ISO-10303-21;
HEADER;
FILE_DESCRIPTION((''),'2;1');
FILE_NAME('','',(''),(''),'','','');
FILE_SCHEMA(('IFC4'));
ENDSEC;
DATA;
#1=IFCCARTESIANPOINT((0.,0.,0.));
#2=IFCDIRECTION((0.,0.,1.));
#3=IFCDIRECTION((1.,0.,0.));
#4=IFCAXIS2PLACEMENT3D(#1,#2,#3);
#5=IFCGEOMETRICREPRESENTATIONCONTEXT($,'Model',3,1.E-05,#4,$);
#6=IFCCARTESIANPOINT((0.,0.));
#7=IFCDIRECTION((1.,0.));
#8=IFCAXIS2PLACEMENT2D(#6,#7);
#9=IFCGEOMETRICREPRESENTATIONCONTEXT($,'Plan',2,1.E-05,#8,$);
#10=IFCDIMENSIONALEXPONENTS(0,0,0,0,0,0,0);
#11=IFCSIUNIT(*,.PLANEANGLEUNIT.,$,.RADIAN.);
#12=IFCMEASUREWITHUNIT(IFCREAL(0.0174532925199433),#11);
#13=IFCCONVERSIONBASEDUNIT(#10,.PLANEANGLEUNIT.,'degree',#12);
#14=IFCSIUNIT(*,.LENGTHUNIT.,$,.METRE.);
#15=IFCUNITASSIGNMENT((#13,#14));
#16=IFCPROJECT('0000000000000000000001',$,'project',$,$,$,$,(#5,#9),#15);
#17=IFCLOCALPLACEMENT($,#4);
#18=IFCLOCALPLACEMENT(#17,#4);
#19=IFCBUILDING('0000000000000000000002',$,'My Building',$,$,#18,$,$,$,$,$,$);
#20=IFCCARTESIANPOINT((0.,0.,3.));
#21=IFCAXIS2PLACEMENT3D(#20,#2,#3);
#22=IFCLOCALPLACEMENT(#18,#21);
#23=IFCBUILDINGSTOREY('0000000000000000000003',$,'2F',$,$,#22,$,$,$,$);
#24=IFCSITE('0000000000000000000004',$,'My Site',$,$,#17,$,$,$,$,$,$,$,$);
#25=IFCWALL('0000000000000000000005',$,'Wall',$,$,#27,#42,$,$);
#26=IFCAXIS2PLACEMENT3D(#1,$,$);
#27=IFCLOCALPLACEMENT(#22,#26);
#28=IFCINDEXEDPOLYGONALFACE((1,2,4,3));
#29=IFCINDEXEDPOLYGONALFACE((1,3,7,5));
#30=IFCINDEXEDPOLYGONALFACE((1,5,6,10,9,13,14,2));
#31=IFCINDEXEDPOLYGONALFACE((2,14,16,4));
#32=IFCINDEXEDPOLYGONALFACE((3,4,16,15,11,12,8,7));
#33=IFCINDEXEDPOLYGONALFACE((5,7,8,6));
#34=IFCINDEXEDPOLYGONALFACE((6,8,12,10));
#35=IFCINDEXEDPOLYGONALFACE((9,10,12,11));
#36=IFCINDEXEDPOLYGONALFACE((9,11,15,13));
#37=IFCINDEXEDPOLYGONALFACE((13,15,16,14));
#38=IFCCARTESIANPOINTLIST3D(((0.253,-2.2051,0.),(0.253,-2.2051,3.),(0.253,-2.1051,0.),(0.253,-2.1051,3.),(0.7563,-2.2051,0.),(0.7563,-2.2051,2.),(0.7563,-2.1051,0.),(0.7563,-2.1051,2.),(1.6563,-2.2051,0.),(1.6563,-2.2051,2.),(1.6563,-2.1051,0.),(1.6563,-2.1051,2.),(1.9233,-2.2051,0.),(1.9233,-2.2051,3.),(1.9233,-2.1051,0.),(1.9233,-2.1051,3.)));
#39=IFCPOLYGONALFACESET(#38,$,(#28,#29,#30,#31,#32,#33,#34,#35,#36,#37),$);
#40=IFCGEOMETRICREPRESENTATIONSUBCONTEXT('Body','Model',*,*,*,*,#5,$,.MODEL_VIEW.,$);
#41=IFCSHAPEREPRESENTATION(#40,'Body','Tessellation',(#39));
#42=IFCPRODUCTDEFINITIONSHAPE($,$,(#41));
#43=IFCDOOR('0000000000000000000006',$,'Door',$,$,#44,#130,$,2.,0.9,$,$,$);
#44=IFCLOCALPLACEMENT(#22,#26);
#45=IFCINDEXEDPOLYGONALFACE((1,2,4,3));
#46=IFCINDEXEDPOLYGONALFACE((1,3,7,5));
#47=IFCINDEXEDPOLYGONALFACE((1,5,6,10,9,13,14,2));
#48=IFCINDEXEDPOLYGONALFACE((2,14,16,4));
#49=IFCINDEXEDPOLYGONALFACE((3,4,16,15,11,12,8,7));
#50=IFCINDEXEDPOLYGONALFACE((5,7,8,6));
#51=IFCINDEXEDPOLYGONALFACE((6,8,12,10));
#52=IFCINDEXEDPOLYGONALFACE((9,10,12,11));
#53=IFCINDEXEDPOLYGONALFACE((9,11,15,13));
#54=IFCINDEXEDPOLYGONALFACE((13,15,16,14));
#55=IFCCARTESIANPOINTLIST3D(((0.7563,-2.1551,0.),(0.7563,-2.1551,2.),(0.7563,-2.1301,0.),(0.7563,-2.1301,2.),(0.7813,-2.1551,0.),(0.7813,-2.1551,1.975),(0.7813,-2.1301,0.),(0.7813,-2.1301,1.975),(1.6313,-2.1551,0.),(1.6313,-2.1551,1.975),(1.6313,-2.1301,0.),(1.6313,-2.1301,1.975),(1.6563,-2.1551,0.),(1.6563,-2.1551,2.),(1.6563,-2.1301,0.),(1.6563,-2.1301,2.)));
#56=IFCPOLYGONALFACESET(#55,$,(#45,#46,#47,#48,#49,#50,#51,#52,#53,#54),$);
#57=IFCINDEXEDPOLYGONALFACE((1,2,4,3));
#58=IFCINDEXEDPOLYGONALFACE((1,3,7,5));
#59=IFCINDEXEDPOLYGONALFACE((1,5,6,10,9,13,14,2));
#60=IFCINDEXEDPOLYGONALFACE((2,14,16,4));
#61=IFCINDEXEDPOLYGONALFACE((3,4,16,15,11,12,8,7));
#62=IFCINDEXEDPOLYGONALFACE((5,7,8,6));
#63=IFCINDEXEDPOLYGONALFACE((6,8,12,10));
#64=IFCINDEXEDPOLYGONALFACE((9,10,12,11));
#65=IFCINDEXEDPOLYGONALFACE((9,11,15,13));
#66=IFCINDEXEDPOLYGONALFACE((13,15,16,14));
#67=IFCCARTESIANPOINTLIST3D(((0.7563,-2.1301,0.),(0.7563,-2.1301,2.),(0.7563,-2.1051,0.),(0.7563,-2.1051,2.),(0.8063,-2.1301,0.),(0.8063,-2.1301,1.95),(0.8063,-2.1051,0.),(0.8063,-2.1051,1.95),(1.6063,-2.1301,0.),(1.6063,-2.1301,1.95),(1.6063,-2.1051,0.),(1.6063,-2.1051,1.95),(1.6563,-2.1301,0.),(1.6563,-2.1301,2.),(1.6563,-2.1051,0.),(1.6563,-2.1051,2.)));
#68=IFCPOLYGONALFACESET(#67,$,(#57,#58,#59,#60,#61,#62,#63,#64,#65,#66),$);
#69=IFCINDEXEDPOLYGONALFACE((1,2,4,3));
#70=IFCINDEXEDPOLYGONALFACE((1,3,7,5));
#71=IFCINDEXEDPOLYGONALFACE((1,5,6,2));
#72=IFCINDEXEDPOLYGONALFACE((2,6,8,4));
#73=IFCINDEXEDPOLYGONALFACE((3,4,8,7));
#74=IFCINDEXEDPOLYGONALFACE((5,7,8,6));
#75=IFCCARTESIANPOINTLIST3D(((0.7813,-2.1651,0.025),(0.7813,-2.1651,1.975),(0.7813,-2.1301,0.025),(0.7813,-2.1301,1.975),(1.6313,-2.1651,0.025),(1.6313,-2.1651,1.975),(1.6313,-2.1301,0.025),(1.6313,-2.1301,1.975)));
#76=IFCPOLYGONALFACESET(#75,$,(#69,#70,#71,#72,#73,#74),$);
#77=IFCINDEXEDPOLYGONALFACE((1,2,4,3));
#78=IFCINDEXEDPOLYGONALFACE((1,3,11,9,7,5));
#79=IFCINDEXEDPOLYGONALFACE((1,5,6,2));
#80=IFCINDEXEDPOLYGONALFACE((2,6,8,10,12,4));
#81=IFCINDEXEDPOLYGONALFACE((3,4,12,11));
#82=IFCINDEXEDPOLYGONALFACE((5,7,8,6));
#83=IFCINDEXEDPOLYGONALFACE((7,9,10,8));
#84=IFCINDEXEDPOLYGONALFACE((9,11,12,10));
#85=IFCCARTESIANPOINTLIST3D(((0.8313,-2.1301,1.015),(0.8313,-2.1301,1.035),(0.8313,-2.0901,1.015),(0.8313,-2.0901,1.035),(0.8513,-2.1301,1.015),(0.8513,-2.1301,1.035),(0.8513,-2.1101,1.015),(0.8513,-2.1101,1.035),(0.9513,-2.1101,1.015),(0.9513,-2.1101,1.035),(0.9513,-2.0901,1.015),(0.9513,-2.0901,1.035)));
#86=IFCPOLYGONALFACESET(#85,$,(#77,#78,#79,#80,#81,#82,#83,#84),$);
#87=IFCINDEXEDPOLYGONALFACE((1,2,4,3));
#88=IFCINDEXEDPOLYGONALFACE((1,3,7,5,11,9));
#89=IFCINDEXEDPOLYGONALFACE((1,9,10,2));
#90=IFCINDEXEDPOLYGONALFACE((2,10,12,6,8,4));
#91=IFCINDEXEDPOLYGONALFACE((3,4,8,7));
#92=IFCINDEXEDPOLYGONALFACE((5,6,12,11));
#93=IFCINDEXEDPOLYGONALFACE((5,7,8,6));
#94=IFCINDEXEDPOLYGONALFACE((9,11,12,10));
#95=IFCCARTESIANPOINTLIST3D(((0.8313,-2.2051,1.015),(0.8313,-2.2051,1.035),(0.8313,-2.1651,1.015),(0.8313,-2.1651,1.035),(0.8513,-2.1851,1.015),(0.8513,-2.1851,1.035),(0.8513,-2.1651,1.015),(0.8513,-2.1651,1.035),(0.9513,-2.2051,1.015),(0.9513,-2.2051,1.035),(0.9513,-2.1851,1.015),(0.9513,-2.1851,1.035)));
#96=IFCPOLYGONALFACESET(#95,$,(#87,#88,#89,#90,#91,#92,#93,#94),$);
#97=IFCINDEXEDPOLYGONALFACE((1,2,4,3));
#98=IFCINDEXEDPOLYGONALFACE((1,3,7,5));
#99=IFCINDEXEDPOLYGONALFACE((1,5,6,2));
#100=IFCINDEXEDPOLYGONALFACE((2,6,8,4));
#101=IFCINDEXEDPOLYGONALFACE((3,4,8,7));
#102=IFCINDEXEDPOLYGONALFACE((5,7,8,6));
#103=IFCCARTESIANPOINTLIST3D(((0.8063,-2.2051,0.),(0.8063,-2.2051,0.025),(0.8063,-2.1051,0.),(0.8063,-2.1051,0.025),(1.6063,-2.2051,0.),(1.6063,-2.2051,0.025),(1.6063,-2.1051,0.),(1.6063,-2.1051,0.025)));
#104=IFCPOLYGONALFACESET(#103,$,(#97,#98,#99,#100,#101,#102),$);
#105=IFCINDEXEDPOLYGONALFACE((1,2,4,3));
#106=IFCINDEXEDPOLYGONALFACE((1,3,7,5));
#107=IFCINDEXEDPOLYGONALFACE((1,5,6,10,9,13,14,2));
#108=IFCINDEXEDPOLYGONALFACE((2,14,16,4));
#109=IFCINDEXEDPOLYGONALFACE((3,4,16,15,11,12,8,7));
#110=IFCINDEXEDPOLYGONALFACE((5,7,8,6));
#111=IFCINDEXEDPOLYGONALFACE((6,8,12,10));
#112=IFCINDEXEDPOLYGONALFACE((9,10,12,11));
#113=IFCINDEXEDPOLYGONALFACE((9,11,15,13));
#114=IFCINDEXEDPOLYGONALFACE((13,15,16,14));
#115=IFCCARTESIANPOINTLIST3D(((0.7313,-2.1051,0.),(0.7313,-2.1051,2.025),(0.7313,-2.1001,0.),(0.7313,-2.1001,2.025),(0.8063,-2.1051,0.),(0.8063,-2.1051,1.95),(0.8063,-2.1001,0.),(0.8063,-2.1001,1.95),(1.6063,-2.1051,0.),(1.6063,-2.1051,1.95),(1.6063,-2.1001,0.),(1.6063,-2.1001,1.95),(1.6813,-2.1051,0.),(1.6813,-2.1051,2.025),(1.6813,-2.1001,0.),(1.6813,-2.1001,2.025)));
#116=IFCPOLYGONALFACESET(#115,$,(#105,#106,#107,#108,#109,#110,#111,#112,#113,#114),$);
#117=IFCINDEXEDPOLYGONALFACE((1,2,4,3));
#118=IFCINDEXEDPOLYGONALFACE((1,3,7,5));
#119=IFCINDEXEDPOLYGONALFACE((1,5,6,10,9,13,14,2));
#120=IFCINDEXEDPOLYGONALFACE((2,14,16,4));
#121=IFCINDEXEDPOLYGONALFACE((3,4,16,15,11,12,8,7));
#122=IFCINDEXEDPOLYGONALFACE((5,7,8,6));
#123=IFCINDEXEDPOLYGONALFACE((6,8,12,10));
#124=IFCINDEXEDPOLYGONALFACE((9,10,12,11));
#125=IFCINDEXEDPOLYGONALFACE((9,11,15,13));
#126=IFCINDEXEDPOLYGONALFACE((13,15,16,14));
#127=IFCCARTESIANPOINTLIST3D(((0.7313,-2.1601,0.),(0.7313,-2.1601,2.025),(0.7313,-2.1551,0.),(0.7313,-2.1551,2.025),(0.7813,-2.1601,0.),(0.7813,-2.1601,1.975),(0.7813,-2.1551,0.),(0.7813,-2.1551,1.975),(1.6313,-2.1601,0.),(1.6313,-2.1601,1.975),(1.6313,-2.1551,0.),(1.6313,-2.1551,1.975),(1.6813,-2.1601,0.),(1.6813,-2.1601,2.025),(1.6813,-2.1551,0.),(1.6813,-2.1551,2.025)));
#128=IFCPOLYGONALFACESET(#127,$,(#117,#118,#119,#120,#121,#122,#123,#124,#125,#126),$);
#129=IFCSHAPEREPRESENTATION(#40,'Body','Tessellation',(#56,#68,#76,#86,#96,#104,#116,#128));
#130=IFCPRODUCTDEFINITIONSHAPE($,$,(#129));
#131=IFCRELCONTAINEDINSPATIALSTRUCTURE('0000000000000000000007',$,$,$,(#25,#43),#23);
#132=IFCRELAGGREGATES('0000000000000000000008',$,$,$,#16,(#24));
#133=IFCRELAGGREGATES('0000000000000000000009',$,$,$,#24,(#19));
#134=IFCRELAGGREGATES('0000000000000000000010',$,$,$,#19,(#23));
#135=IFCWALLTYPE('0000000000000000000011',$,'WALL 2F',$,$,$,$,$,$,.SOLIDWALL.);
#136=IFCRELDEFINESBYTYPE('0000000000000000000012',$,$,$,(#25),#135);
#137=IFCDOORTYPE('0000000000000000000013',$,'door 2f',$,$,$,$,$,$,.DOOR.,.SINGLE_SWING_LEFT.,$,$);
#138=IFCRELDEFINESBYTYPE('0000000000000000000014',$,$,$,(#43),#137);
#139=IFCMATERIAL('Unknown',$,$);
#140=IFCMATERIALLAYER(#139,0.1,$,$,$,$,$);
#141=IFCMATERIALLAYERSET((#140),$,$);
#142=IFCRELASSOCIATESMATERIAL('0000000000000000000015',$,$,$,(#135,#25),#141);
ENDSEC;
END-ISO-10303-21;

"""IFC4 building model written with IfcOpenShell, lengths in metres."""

from ifc_helpers import new_model, entity, si_unit, converted_unit, frame, origin_with_axes, origin_2d_with_axis, place, context, subcontext, project, spatial, line, indexed_curve, outline, extrude, shape, source, transform, mapped, material, layer, layer_set, layer_usage, type_object, type_shapes, element, fill, save


model = new_model("IFC4")

# Units and contexts
model_context = context("Model", 3, precision=1e-05, world=origin_with_axes())
plan_context = context("Plan", 2, precision=1e-05, world=origin_2d_with_axis())
body_context_1 = subcontext(model_context, "Body", "Model", "MODEL_VIEW")
body_context_2 = subcontext(plan_context, "Body", "Plan", "PLAN_VIEW")
ifc_project = project(units=[converted_unit("PLANEANGLEUNIT", "degree", entity("IfcReal", 0.0174532925199433), si_unit("PLANEANGLEUNIT", "RADIAN"), dimensions=[0, 0, 0, 0, 0, 0, 0]), si_unit("LENGTHUNIT", "METRE")], contexts=[model_context, plan_context])

# Site, building, storey
site_placement = place(None, origin_with_axes())
site = spatial("IfcSite", under=ifc_project, at=site_placement, Name="My Site")
building_placement = place(site_placement, origin_with_axes())
building = spatial("IfcBuilding", under=site, at=building_placement, Name="My Building")
storey_placement = place(building_placement, frame((0.0, 0.0, 3.0), z_axis=(0.0, 0.0, 1.0), x_axis=(1.0, 0.0, 0.0)))
storey = spatial("IfcBuildingStorey", under=building, at=storey_placement, Name="2F")

# Shared definitions
ifc_material = material(Name="Unknown")

# Shared definitions
ifc_layer = layer(ifc_material, 0.1)
ifc_layer_set = layer_set([ifc_layer])
wall_type = type_object("IfcWallType", Name="WALL 2F", PredefinedType="SOLIDWALL", material=ifc_layer_set)

# Wall, opening, door
ifc_layer_usage_1 = layer_usage(ifc_layer_set, "AXIS2", "POSITIVE", 0.0)
wall_1_placement = place(storey_placement, frame((1.9233, -2.1051, 0.0), z_axis=(0.0, 0.0, 1.0), x_axis=(-1.0, 0.0, 0.0)))
wall_1 = element("IfcWall", 1, at=wall_1_placement, inside=storey, type_object=wall_type, material=ifc_layer_usage_1, Name="Wall", context=body_context_1, shape_type="SweptSolid", body=[
    extrude(outline(indexed_curve([(0.0, 0.0), (0.0, 0.1), (1.6703, 0.1), (1.6703, 0.0)], segments=[line(1, 2, 3, 4, 1)])), origin_with_axes(), (0.0, 0.0, 1.0), 3.0),
])
shared_shape_1 = source(origin_with_axes(), body_context_1, "Body", "SweptSolid", [
    extrude(outline(indexed_curve([(0.0, 0.0), (0.9, 0.0), (0.9, 2.0), (0.0, 2.0)], segments=[line(1, 2, 3, 4, 1)])), frame((0.0, -0.6, 0.0), z_axis=(0.0, -1.0, 0.0), x_axis=(1.0, 0.0, 0.0)), (0.0, 0.0, -1.0), 1.2),
])
opening_1_placement = place(wall_1_placement, frame((0.2669, 0.0, 0.0), z_axis=(0.0, 0.0, 1.0), x_axis=(1.0, 0.0, 0.0)))
opening_1 = element("IfcOpeningElement", 2, at=opening_1_placement, cuts=wall_1, PredefinedType="OPENING", context=body_context_1, shape_type="MappedRepresentation", body=[
    mapped(shared_shape_1, transform((0.0, 0.0, 0.0), x_axis=(1.0, 0.0, 0.0), y_axis=(0.0, 1.0, 0.0), z_axis=(0.0, 0.0, 1.0), scale=1.0)),
])
door_type_1 = type_object("IfcDoorType", Name="door 2f", OperationType="SINGLE_SWING_LEFT", PredefinedType="DOOR")
shared_shape_2 = source(origin_with_axes(), body_context_1, "Body", "SweptSolid", [
    extrude(outline(indexed_curve([(0.0, 0.0), (0.0, 2.0), (0.9, 2.0), (0.9, 0.0), (0.875, 0.0), (0.875, 1.975), (0.025, 1.975), (0.025, 0.0)], segments=[line(1, 2, 3, 4, 5, 6, 7, 8, 1)])), frame((0.0, 0.025, 0.0), z_axis=(0.0, -1.0, 0.0), x_axis=(1.0, 0.0, 0.0)), (0.0, 0.0, -1.0), 0.025),
    extrude(outline(indexed_curve([(0.0, 0.0), (0.0, 2.0), (0.9, 2.0), (0.9, 0.0), (0.85, 0.0), (0.85, 1.95), (0.05, 1.95), (0.05, 0.0)], segments=[line(1, 2, 3, 4, 5, 6, 7, 8, 1)])), frame((0.0, 0.0, 0.0), z_axis=(0.0, -1.0, 0.0), x_axis=(1.0, 0.0, 0.0)), (0.0, 0.0, -1.0), 0.025),
    extrude(outline(indexed_curve([(0.0, 0.0), (0.85, 0.0), (0.85, 0.035), (0.0, 0.035)], segments=[line(1, 2, 3, 4, 1)])), frame((0.025, 0.025, 0.025), z_axis=(0.0, 0.0, 1.0), x_axis=(1.0, 0.0, 0.0)), (0.0, 0.0, 1.0), 1.95),
    extrude(outline(indexed_curve([(0.0, 0.0), (0.0, -0.04), (-0.12, -0.04), (-0.12, -0.02), (-0.02, -0.02), (-0.02, 0.0)], segments=[line(1, 2, 3, 4, 5, 6, 1)])), frame((0.825, 0.025, 1.015), z_axis=(0.0, 0.0, 1.0), x_axis=(1.0, 0.0, 0.0)), (0.0, 0.0, 1.0), 0.02),
    extrude(outline(indexed_curve([(0.0, 0.0), (0.0, 0.04), (-0.12, 0.04), (-0.12, 0.02), (-0.02, 0.02), (-0.02, 0.0)], segments=[line(1, 2, 3, 4, 5, 6, 1)])), frame((0.825, 0.06, 1.015), z_axis=(0.0, 0.0, 1.0), x_axis=(1.0, 0.0, 0.0)), (0.0, 0.0, 1.0), 0.02),
    extrude(outline(indexed_curve([(0.0, 0.0), (0.8, 0.0), (0.8, 0.1), (0.0, 0.1)], segments=[line(1, 2, 3, 4, 1)])), frame((0.05, 0.0, 0.0), z_axis=(0.0, 0.0, 1.0), x_axis=(1.0, 0.0, 0.0)), (0.0, 0.0, 1.0), 0.025),
    extrude(outline(indexed_curve([(0.0, 0.0), (0.0, 2.025), (0.95, 2.025), (0.95, 0.0), (0.875, 0.0), (0.875, 1.95), (0.075, 1.95), (0.075, 0.0)], segments=[line(1, 2, 3, 4, 5, 6, 7, 8, 1)])), frame((-0.025, -0.005, 0.0), z_axis=(0.0, -1.0, 0.0), x_axis=(1.0, 0.0, 0.0)), (0.0, 0.0, -1.0), 0.005),
    extrude(outline(indexed_curve([(0.0, 0.0), (0.0, 2.025), (0.95, 2.025), (0.95, 0.0), (0.9, 0.0), (0.9, 1.975), (0.05, 1.975), (0.05, 0.0)], segments=[line(1, 2, 3, 4, 5, 6, 7, 8, 1)])), frame((-0.025, 0.05, 0.0), z_axis=(0.0, -1.0, 0.0), x_axis=(1.0, 0.0, 0.0)), (0.0, 0.0, -1.0), 0.005),
])
shared_shape_3 = source(origin_with_axes(), body_context_2, "Body", "Curve2D", [
    entity("IfcIndexedPolyCurve", entity("IfcCartesianPointList2D", [[0.0, 0.0], [0.0, 0.05], [0.025, 0.05], [0.025, 0.025], [0.05, 0.025], [0.05, 0.0]]), [entity("IfcLineIndex", [1, 2, 3, 4, 5, 6, 1])]),
    entity("IfcIndexedPolyCurve", entity("IfcCartesianPointList2D", [[0.9, 0.0], [0.9, 0.05], [0.875, 0.05], [0.875, 0.025], [0.85, 0.025], [0.85, 0.0]]), [entity("IfcLineIndex", [1, 2, 3, 4, 5, 6, 1])]),
    entity("IfcTrimmedCurve", entity("IfcEllipse", entity("IfcAxis2Placement2D", entity("IfcCartesianPoint", [0.06, 0.05]), entity("IfcDirection", [1.0, 0.0])), 0.815, 0.85), [entity("IfcCartesianPoint", [0.875, 0.05])], [entity("IfcCartesianPoint", [0.06, 0.9])], True, "CARTESIAN"),
    entity("IfcIndexedPolyCurve", entity("IfcCartesianPointList2D", [[0.025, 0.05], [0.06, 0.05], [0.06, 0.9], [0.025, 0.9]]), [entity("IfcLineIndex", [1, 2, 3, 4, 1])]),
])
type_shapes(door_type_1, [shared_shape_2, shared_shape_3])
door_1_placement = place(opening_1_placement, frame((0.0, 0.0, 0.0), z_axis=(0.0, 0.0, 1.0), x_axis=(1.0, 0.0, 0.0)))
door_1 = element("IfcDoor", 3, at=door_1_placement, inside=storey, type_object=door_type_1, Name="Door", OverallHeight=2.0, OverallWidth=0.9, shapes=[
    shape(body_context_1, "Body", "MappedRepresentation", [mapped(shared_shape_2, transform((0.0, 0.0, 0.0), x_axis=(1.0, 0.0, 0.0), y_axis=(0.0, 1.0, 0.0), z_axis=(0.0, 0.0, 1.0), scale=1.0))]),
    shape(body_context_2, "Body", "MappedRepresentation", [mapped(shared_shape_3, transform((0.0, 0.0, 0.0), x_axis=(1.0, 0.0, 0.0), y_axis=(0.0, 1.0, 0.0), z_axis=(0.0, 0.0, 1.0), scale=1.0))]),
])
fill(opening_1, door_1)

save(model, "model.ifc")
